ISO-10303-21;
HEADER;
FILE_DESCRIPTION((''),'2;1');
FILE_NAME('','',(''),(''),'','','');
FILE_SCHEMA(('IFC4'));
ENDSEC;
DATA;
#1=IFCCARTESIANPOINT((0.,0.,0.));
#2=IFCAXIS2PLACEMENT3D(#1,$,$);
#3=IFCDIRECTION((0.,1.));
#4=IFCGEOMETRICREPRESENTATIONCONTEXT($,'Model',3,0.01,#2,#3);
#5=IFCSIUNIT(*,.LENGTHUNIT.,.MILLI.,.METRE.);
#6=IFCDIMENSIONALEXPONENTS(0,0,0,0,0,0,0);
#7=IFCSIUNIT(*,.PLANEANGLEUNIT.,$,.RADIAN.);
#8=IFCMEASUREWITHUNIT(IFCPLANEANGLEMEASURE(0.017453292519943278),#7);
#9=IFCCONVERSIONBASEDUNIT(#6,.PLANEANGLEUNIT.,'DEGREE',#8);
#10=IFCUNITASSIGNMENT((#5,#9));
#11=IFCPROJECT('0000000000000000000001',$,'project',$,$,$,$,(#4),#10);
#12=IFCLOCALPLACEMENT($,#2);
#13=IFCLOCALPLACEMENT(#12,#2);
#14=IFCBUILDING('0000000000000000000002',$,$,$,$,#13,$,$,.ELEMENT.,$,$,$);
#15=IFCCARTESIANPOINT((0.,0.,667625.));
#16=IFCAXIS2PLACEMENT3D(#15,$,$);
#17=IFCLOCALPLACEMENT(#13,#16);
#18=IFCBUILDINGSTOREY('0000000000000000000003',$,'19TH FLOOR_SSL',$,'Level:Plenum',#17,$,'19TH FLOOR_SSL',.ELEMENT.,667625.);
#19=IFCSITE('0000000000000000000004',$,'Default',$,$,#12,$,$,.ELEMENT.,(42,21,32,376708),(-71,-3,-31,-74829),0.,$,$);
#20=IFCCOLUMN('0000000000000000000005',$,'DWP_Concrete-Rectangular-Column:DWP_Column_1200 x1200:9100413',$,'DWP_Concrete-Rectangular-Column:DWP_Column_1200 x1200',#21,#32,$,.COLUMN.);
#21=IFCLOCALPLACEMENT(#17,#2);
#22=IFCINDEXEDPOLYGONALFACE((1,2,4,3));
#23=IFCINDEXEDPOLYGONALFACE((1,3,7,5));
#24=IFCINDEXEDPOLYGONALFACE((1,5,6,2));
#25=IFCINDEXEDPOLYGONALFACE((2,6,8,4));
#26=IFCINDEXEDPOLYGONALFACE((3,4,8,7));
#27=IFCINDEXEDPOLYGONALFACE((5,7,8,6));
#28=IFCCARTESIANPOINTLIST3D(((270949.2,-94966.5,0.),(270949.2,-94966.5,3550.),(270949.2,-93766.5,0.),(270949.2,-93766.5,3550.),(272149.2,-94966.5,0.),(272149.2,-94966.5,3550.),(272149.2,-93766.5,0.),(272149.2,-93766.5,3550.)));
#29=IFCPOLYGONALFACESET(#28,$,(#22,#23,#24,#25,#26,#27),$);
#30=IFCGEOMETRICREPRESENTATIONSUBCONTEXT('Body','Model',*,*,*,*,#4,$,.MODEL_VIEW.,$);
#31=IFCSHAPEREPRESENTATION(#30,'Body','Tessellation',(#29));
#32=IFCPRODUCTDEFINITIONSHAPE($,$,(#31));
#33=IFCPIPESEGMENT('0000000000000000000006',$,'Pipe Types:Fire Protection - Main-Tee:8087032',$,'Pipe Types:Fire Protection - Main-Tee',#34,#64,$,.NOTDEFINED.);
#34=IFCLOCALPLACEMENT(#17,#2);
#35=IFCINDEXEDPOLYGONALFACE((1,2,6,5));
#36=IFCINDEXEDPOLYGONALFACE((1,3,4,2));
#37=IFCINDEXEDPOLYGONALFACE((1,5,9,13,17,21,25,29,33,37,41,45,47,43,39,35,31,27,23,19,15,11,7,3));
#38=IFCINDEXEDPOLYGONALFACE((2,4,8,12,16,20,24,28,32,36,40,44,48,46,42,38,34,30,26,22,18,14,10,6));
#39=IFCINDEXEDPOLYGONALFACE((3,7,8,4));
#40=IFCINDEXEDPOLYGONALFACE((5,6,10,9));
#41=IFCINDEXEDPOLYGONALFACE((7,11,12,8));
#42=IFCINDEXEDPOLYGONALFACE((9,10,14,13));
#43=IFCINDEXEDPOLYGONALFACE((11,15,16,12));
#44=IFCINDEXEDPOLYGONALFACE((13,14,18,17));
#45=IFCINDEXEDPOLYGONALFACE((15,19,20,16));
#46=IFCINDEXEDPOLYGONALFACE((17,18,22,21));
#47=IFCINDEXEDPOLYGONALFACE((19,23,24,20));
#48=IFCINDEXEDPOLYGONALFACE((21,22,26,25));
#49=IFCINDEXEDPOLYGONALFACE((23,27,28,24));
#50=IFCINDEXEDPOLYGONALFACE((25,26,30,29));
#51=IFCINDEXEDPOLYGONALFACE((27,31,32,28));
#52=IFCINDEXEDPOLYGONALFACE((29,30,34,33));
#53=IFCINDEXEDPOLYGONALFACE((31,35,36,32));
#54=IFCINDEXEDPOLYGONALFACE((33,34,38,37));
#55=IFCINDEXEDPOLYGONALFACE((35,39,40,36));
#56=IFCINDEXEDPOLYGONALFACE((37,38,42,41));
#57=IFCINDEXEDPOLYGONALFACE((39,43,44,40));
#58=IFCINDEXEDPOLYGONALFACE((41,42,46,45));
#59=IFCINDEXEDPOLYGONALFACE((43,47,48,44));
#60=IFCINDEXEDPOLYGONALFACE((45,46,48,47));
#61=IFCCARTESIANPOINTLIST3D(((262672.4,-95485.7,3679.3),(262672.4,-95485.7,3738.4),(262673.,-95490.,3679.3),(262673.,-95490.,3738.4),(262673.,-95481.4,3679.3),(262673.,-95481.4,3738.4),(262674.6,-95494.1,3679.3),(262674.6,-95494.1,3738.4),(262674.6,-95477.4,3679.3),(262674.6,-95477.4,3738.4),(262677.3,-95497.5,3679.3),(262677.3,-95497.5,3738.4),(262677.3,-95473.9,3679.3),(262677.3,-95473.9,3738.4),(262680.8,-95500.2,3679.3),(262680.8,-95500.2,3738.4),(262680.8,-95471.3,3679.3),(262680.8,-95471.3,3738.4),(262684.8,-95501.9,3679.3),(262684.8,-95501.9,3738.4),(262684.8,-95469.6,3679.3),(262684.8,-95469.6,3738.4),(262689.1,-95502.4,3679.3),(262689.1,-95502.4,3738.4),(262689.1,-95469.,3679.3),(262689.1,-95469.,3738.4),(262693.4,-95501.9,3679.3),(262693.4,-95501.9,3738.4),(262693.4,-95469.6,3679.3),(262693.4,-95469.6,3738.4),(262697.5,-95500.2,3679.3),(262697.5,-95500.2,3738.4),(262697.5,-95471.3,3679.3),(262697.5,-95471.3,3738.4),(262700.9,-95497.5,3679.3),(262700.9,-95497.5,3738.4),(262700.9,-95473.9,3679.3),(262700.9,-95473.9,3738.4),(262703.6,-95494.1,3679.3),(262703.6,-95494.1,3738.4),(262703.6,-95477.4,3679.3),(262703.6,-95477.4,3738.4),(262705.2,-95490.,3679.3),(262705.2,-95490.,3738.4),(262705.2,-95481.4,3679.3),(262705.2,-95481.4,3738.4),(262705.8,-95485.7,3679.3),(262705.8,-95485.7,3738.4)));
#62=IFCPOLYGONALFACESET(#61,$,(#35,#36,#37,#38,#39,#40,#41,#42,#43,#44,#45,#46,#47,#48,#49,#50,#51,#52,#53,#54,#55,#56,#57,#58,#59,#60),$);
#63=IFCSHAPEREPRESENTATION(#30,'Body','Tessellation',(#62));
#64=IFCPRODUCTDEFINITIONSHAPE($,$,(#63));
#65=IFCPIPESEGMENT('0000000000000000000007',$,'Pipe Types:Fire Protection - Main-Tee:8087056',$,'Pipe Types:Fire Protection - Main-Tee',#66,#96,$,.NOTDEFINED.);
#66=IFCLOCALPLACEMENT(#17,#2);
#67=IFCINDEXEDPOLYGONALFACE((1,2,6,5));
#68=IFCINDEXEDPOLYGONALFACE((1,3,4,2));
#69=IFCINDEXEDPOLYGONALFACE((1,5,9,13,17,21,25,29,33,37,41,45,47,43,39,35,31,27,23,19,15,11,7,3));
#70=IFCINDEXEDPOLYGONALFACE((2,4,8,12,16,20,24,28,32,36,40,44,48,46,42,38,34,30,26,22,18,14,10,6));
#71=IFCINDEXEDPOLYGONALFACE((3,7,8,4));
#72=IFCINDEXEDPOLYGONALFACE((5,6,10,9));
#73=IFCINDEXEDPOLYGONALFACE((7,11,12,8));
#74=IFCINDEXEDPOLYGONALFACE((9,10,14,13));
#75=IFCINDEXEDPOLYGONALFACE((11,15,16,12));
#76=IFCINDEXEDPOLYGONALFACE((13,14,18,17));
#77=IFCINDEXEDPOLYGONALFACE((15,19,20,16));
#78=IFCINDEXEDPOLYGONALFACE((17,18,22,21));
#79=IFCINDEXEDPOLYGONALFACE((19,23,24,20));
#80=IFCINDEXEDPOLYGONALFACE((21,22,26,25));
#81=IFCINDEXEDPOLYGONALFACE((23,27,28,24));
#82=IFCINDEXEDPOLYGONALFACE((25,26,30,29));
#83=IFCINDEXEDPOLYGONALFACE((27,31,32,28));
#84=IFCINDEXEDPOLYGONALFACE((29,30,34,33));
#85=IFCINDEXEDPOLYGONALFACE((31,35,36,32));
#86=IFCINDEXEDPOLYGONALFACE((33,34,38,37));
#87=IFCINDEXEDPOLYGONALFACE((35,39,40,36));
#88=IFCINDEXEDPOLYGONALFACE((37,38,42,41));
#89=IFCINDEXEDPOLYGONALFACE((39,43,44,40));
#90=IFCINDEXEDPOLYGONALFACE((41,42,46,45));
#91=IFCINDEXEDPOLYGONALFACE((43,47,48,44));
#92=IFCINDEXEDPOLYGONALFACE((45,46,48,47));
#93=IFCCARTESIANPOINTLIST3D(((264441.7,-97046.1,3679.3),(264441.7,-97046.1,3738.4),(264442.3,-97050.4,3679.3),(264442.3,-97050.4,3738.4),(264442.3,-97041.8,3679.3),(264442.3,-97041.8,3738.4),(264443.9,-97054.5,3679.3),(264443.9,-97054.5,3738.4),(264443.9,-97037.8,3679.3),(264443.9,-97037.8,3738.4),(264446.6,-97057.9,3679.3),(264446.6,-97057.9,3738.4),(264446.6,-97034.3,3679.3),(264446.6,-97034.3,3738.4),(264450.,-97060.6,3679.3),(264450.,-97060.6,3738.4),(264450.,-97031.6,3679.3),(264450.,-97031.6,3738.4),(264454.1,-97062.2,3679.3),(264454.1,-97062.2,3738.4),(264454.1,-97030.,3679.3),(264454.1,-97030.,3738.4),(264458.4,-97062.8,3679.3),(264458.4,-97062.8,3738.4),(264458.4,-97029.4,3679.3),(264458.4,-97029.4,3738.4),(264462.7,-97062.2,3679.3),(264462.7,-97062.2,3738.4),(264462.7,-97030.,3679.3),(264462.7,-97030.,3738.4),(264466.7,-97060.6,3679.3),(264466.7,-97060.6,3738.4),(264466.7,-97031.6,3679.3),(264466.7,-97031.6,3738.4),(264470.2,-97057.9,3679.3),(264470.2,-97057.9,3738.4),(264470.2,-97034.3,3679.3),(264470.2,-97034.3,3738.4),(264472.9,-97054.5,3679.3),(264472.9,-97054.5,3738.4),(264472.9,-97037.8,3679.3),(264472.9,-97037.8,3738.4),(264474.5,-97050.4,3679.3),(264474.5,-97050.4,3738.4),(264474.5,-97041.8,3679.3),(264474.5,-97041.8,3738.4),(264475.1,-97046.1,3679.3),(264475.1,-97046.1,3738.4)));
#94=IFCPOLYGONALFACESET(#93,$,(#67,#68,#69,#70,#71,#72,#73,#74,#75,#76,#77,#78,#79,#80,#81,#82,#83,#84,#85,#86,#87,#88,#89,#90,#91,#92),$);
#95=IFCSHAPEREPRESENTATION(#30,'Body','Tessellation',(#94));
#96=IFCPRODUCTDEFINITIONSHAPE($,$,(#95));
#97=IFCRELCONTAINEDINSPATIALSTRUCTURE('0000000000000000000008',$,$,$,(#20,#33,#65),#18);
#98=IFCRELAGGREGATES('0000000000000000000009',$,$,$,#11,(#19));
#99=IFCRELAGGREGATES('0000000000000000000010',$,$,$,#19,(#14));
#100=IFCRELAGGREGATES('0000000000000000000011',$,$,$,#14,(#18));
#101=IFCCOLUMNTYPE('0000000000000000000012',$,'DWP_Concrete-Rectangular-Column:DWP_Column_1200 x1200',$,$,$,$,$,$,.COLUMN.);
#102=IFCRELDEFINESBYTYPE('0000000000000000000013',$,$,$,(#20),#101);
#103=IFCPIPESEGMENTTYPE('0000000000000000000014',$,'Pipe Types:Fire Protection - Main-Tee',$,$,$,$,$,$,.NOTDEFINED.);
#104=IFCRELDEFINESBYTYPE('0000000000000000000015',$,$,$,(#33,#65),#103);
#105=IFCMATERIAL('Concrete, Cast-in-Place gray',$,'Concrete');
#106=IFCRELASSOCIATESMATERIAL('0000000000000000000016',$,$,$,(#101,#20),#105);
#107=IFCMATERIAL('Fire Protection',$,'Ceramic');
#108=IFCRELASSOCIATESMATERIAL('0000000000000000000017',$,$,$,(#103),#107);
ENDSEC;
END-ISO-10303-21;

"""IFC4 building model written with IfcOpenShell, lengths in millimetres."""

from ifc_helpers import new_model, entity, si_unit, converted_unit, direction, frame, origin, place, context, subcontext, project, spatial, arc, indexed_curve, outline, extrude, source, transform, mapped, material, type_object, type_shapes, element, save


model = new_model("IFC4")

# Units and contexts
model_context = context("Model", 3, precision=0.01, world=origin(), true_north=direction((0.0, 1.0)))
body_context = subcontext(model_context, "Body", "Model", "MODEL_VIEW")
ifc_project = project(units=[si_unit("LENGTHUNIT", "METRE", prefix="MILLI"), converted_unit("PLANEANGLEUNIT", "DEGREE", entity("IfcPlaneAngleMeasure", 0.017453292519943278), si_unit("PLANEANGLEUNIT", "RADIAN"), dimensions=[0, 0, 0, 0, 0, 0, 0])], contexts=[model_context])

# Site, building, storey
site_placement = place(None, origin())
site = spatial("IfcSite", under=ifc_project, at=site_placement, Name="Default", CompositionType="ELEMENT", RefLatitude=(42, 21, 32, 376708), RefLongitude=(-71, -3, -31, -74829), RefElevation=0.0)
building_placement = place(site_placement, origin())
building = spatial("IfcBuilding", under=site, at=building_placement, CompositionType="ELEMENT")
storey_placement = place(building_placement, frame((0.0, 0.0, 667625.0)))
storey = spatial("IfcBuildingStorey", under=building, at=storey_placement, Name="19TH FLOOR_SSL", ObjectType="Level:Plenum", LongName="19TH FLOOR_SSL", CompositionType="ELEMENT", Elevation=667625.0)

# Column
ifc_material_1 = material(Name="Concrete, Cast-in-Place gray", Category="Concrete")
column_type_1 = type_object("IfcColumnType", Name="DWP_Concrete-Rectangular-Column:DWP_Column_1200 x1200", PredefinedType="COLUMN", material=ifc_material_1)
shared_shape_1 = source(origin(), body_context, "Body", "SweptSolid", [
    extrude(outline(indexed_curve([(-600.0, -600.0), (600.0, -600.0), (600.0, 600.0), (-600.0, 600.0), (-600.0, -600.0)], self_intersect=False)), frame((271549.2, -94366.5, 667625.0), z_axis=(0.0, 0.0, 1.0), x_axis=(-1.0, 0.0, 0.0)), (0.0, 0.0, 1.0), 3550.0),
])
type_shapes(column_type_1, [shared_shape_1])
column_1_placement = place(storey_placement, frame((0.0, 0.0, -667625.0)))
element("IfcColumn", 1, at=column_1_placement, inside=storey, type_object=column_type_1, material=ifc_material_1, Name="DWP_Concrete-Rectangular-Column:DWP_Column_1200 x1200:9100413", ObjectType="DWP_Concrete-Rectangular-Column:DWP_Column_1200 x1200", PredefinedType="COLUMN", context=body_context, shape_type="MappedRepresentation", body=[
    mapped(shared_shape_1, transform((0.0, 0.0, 0.0), scale=1.0)),
])

# Pipe segments
ifc_material_2 = material(Name="Fire Protection", Category="Ceramic")
pipe_segment_type = type_object("IfcPipeSegmentType", Name="Pipe Types:Fire Protection - Main-Tee", PredefinedType="NOTDEFINED", material=ifc_material_2)
pipe_segment_1_placement = place(storey_placement, origin())
element("IfcPipeSegment", 2, at=pipe_segment_1_placement, inside=storey, type_object=pipe_segment_type, Name="Pipe Types:Fire Protection - Main-Tee:8087032", ObjectType="Pipe Types:Fire Protection - Main-Tee", PredefinedType="NOTDEFINED", context=body_context, shape_type="SweptSolid", body=[
    extrude(outline(indexed_curve([(16.7, 0.0), (11.8, 11.8), (0.0, 16.7), (-11.8, 11.8), (-16.7, 0.0), (-11.8, -11.8), (0.0, -16.7), (11.8, -11.8)], segments=[arc(1, 2, 3), arc(3, 4, 5), arc(5, 6, 7), arc(7, 8, 1)], self_intersect=False)), frame((262689.1, -95485.7, 3679.3)), (0.0, 0.0, 1.0), 59.1),
])
pipe_segment_2_placement = place(storey_placement, origin())
element("IfcPipeSegment", 3, at=pipe_segment_2_placement, inside=storey, type_object=pipe_segment_type, Name="Pipe Types:Fire Protection - Main-Tee:8087056", ObjectType="Pipe Types:Fire Protection - Main-Tee", PredefinedType="NOTDEFINED", context=body_context, shape_type="SweptSolid", body=[
    extrude(outline(indexed_curve([(16.7, 0.0), (11.8, 11.8), (0.0, 16.7), (-11.8, 11.8), (-16.7, 0.0), (-11.8, -11.8), (0.0, -16.7), (11.8, -11.8)], segments=[arc(1, 2, 3), arc(3, 4, 5), arc(5, 6, 7), arc(7, 8, 1)], self_intersect=False)), frame((264458.4, -97046.1, 3679.3)), (0.0, 0.0, 1.0), 59.1),
])

save(model, "model.ifc")
